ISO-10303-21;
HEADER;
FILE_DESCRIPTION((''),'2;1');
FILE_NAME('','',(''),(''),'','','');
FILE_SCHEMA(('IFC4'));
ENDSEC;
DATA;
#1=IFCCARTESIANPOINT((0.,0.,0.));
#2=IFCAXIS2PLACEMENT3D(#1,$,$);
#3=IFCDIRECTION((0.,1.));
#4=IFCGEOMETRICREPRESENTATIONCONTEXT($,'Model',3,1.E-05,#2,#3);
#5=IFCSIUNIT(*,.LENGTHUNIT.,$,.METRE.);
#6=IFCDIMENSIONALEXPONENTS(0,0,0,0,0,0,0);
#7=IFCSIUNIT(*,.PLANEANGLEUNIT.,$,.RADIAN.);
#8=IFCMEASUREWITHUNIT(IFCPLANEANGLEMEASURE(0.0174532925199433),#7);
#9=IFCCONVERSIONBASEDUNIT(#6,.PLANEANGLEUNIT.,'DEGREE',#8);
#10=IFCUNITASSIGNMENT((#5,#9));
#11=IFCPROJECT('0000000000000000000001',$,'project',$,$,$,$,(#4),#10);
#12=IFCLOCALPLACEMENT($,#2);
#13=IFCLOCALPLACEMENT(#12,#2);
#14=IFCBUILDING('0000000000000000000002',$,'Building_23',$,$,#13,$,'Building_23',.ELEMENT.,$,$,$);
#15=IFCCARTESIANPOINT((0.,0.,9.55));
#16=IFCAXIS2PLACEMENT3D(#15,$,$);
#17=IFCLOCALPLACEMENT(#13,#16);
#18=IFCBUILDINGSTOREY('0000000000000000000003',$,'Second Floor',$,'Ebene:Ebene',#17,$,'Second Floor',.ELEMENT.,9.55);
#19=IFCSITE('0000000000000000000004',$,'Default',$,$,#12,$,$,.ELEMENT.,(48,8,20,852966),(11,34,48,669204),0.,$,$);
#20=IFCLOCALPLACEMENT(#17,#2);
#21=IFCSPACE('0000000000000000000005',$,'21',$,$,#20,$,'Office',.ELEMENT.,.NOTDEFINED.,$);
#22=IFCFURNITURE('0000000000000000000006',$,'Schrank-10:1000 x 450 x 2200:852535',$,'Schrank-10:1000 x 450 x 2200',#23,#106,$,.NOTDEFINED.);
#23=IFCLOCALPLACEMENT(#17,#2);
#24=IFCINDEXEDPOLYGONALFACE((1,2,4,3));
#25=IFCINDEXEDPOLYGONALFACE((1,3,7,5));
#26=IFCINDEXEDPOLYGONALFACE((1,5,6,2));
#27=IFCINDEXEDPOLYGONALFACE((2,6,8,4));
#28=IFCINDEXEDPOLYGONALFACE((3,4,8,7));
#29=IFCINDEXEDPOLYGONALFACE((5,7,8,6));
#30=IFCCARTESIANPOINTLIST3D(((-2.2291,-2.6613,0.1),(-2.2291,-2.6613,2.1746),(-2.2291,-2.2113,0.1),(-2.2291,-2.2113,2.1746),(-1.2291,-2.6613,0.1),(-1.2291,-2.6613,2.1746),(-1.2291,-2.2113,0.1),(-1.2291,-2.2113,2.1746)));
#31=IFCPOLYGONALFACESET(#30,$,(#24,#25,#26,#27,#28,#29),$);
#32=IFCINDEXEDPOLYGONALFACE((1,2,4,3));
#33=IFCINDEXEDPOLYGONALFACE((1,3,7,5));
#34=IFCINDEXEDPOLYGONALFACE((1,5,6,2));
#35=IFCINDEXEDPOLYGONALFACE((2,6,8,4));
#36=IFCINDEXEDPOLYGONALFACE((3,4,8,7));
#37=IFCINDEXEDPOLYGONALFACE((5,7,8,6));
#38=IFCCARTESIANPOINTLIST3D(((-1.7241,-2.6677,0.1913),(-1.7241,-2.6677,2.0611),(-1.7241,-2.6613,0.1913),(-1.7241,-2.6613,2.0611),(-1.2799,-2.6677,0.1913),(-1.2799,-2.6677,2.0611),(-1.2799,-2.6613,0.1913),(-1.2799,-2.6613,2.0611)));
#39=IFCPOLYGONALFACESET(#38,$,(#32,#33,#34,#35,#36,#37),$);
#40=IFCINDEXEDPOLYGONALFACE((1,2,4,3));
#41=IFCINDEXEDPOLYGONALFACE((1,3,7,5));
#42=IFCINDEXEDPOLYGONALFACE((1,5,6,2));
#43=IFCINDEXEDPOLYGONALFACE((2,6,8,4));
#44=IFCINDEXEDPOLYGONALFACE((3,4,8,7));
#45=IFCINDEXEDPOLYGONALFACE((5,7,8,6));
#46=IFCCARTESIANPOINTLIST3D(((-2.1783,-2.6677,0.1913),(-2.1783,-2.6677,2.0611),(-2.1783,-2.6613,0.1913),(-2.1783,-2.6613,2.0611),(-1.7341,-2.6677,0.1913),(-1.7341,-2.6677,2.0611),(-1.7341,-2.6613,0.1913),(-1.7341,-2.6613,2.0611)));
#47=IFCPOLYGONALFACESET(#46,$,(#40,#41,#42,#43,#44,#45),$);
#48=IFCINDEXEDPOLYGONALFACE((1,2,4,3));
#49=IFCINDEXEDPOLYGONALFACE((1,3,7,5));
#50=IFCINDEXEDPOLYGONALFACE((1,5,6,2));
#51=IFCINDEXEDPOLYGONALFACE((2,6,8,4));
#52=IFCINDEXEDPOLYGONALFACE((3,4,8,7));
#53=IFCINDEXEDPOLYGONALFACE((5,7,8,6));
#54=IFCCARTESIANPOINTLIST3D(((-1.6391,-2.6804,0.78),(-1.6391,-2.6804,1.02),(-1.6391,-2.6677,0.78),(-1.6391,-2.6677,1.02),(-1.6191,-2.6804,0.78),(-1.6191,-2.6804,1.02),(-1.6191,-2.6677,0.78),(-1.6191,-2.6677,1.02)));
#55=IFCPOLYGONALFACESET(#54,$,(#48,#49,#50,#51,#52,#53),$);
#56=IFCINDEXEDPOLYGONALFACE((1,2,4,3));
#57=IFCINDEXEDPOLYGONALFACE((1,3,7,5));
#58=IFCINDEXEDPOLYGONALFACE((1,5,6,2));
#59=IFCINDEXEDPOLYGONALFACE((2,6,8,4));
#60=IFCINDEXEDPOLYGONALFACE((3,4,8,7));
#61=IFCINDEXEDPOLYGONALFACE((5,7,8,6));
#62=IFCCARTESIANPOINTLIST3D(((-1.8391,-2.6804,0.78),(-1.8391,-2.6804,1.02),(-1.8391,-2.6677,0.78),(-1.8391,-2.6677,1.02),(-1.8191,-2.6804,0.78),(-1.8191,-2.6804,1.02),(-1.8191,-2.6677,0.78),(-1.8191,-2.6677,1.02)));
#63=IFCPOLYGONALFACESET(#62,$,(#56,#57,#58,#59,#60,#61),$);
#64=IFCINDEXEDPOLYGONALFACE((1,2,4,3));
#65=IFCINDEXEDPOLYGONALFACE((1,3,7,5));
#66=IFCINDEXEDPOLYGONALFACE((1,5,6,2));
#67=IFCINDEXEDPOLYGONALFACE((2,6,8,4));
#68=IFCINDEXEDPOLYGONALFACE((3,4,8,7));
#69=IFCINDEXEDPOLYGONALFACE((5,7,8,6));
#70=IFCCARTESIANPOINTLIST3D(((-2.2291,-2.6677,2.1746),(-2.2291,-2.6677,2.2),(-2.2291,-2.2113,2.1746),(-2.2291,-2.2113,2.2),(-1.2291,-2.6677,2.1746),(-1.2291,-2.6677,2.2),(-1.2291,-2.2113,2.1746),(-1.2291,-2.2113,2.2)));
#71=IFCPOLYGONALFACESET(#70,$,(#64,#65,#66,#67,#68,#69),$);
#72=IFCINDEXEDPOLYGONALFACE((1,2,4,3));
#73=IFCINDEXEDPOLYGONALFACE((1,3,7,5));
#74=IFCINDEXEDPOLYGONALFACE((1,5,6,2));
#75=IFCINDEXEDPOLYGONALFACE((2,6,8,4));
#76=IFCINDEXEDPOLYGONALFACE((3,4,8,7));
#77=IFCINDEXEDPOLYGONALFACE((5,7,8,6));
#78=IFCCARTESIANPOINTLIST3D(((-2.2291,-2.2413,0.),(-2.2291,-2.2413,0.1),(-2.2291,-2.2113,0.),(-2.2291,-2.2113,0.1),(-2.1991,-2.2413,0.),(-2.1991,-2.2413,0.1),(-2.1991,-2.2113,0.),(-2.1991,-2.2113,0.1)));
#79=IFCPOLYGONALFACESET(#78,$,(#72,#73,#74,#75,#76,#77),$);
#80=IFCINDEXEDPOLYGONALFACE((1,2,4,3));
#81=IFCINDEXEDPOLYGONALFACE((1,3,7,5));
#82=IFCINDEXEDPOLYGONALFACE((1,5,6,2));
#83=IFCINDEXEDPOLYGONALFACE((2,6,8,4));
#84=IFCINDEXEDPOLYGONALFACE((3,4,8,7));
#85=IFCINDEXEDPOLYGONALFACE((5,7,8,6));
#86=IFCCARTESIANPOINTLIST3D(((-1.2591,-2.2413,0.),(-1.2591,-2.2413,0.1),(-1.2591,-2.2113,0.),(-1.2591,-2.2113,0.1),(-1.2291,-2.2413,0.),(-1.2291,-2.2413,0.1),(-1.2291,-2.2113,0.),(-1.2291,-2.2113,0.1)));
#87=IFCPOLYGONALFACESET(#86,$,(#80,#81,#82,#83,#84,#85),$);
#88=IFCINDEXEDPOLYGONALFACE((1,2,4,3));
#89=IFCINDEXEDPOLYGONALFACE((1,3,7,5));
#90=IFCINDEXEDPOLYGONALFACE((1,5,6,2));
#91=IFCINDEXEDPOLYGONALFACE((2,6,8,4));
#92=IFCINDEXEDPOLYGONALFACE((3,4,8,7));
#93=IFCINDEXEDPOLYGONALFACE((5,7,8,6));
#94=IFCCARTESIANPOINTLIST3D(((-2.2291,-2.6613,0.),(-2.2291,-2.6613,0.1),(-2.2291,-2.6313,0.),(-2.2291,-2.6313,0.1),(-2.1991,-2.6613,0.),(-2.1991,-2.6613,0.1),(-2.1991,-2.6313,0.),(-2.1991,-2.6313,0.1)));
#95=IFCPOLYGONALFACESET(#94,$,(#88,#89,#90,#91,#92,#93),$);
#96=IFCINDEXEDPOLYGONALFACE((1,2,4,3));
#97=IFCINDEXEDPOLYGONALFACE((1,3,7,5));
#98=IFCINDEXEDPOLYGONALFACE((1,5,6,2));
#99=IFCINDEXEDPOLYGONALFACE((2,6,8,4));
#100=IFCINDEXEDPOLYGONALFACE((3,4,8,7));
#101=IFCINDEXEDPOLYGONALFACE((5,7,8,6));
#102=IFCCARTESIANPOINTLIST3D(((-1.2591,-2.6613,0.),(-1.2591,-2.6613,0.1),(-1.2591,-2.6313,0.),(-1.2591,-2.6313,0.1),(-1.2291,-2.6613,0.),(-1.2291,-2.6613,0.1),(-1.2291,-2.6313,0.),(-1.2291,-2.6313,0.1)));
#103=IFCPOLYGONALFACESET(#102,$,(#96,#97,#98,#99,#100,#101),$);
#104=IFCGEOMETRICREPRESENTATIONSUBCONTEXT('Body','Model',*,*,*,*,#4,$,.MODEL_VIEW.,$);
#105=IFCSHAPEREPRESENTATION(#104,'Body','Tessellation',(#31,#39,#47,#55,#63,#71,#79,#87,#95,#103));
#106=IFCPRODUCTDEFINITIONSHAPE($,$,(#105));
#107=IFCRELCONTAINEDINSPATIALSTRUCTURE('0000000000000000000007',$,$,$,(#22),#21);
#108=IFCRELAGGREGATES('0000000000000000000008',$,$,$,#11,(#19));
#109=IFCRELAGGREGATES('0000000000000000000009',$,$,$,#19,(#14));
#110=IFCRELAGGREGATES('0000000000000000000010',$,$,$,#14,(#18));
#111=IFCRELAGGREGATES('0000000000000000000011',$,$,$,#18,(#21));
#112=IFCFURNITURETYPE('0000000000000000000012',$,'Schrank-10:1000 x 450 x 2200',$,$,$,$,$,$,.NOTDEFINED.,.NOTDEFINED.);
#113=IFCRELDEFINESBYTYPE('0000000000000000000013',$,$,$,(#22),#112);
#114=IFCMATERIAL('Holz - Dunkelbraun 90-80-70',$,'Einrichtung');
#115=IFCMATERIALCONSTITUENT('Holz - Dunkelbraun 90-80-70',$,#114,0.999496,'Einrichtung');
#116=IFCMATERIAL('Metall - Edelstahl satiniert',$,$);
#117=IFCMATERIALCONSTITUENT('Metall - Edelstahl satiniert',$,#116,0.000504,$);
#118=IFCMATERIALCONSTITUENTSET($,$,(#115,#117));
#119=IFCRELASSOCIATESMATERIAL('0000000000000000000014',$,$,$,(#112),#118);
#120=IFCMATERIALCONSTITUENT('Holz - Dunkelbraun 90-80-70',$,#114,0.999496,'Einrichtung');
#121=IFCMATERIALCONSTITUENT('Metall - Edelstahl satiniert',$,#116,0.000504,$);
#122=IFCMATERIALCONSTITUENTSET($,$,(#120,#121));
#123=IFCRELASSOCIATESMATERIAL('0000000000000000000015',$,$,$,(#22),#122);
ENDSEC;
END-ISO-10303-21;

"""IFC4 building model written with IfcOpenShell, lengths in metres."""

from ifc_helpers import new_model, entity, si_unit, converted_unit, direction, frame, origin, place, context, subcontext, project, spatial, indexed_curve, outline, extrude, source, transform, mapped, material, constituent, constituent_set, type_object, type_shapes, element, save


model = new_model("IFC4")

# Units and contexts
model_context = context("Model", 3, precision=1e-05, world=origin(), true_north=direction((0.0, 1.0)))
body_context = subcontext(model_context, "Body", "Model", "MODEL_VIEW")
ifc_project = project(units=[si_unit("LENGTHUNIT", "METRE"), converted_unit("PLANEANGLEUNIT", "DEGREE", entity("IfcPlaneAngleMeasure", 0.0174532925199433), si_unit("PLANEANGLEUNIT", "RADIAN"), dimensions=[0, 0, 0, 0, 0, 0, 0])], contexts=[model_context])

# Site, building, storey
site_placement = place(None, origin())
site = spatial("IfcSite", under=ifc_project, at=site_placement, Name="Default", CompositionType="ELEMENT", RefLatitude=(48, 8, 20, 852966), RefLongitude=(11, 34, 48, 669204), RefElevation=0.0)
building_placement = place(site_placement, origin())
building = spatial("IfcBuilding", under=site, at=building_placement, Name="Building_23", LongName="Building_23", CompositionType="ELEMENT")
storey_placement = place(building_placement, frame((0.0, 0.0, 9.55)))
storey = spatial("IfcBuildingStorey", under=building, at=storey_placement, Name="Second Floor", ObjectType="Ebene:Ebene", LongName="Second Floor", CompositionType="ELEMENT", Elevation=9.55)

# Shared definitions
space_1_placement = place(storey_placement, origin())
space_1 = spatial("IfcSpace", under=storey, at=space_1_placement, Name="21", LongName="Office", CompositionType="ELEMENT", PredefinedType="NOTDEFINED")

# Furniture
ifc_material_1 = material(Name="Holz - Dunkelbraun 90-80-70", Category="Einrichtung")
ifc_constituent_1 = constituent(ifc_material_1, Name="Holz - Dunkelbraun 90-80-70", Category="Einrichtung", fraction=0.999496)
ifc_material_2 = material(Name="Metall - Edelstahl satiniert")
ifc_constituent_2 = constituent(ifc_material_2, Name="Metall - Edelstahl satiniert", fraction=0.000504)
ifc_constituent_set_1 = constituent_set(constituents=[ifc_constituent_1, ifc_constituent_2])
ifc_constituent_3 = constituent(ifc_material_1, Name="Holz - Dunkelbraun 90-80-70", Category="Einrichtung", fraction=0.999496)
ifc_constituent_4 = constituent(ifc_material_2, Name="Metall - Edelstahl satiniert", fraction=0.000504)
ifc_constituent_set_2 = constituent_set(constituents=[ifc_constituent_3, ifc_constituent_4])
furniture_type_1 = type_object("IfcFurnitureType", Name="Schrank-10:1000 x 450 x 2200", AssemblyPlace="NOTDEFINED", PredefinedType="NOTDEFINED", material=ifc_constituent_set_2)
shared_shape_1 = source(origin(), body_context, "Body", "SweptSolid", [
    extrude(outline(indexed_curve([(-0.225, -0.5), (0.225, -0.5), (0.225, 0.5), (-0.225, 0.5), (-0.225, -0.5)], self_intersect=False)), frame((-0.2692, -0.3632, 0.1), z_axis=(0.0, 0.0, 1.0), x_axis=(0.0, 1.0, 0.0)), (0.0, 0.0, 1.0), 2.0746),
    extrude(outline(indexed_curve([(-0.0032, -0.2221), (0.0032, -0.2221), (0.0032, 0.2221), (-0.0032, 0.2221), (-0.0032, -0.2221)], self_intersect=False)), frame((-0.0421, -0.5913, 0.1913), z_axis=(0.0, 0.0, 1.0), x_axis=(0.0, 1.0, 0.0)), (0.0, 0.0, 1.0), 1.8698),
    extrude(outline(indexed_curve([(-0.0032, -0.2221), (0.0032, -0.2221), (0.0032, 0.2221), (-0.0032, 0.2221), (-0.0032, -0.2221)], self_intersect=False)), frame((-0.4963, -0.5913, 0.1913), z_axis=(0.0, 0.0, 1.0), x_axis=(0.0, 1.0, 0.0)), (0.0, 0.0, 1.0), 1.8698),
    extrude(outline(indexed_curve([(-0.0063, -0.01), (0.0063, -0.01), (0.0063, 0.01), (-0.0063, 0.01), (-0.0063, -0.01)], self_intersect=False)), frame((-0.1692, -0.6009, 0.78), z_axis=(0.0, 0.0, 1.0), x_axis=(0.0, 1.0, 0.0)), (0.0, 0.0, 1.0), 0.24),
    extrude(outline(indexed_curve([(-0.0063, -0.01), (0.0063, -0.01), (0.0063, 0.01), (-0.0063, 0.01), (-0.0063, -0.01)], self_intersect=False)), frame((-0.3692, -0.6009, 0.78), z_axis=(0.0, 0.0, 1.0), x_axis=(0.0, 1.0, 0.0)), (0.0, 0.0, 1.0), 0.24),
    extrude(outline(indexed_curve([(-0.5, -0.2282), (0.5, -0.2282), (0.5, 0.2282), (-0.5, 0.2282), (-0.5, -0.2282)], self_intersect=False)), frame((-0.2692, -0.3663, 2.1746), z_axis=(0.0, 0.0, 1.0), x_axis=(-1.0, 0.0, 0.0)), (0.0, 0.0, 1.0), 0.0254),
    extrude(outline(indexed_curve([(-0.015, -0.015), (0.015, -0.015), (0.015, 0.015), (-0.015, 0.015), (-0.015, -0.015)], self_intersect=False)), frame((-0.7542, -0.1532, 0.0), z_axis=(0.0, 0.0, 1.0), x_axis=(-1.0, 0.0, 0.0)), (0.0, 0.0, 1.0), 0.1),
    extrude(outline(indexed_curve([(-0.015, -0.015), (0.015, -0.015), (0.015, 0.015), (-0.015, 0.015), (-0.015, -0.015)], self_intersect=False)), frame((0.2158, -0.1532, 0.0), z_axis=(0.0, 0.0, 1.0), x_axis=(0.0, -1.0, 0.0)), (0.0, 0.0, 1.0), 0.1),
    extrude(outline(indexed_curve([(-0.015, -0.015), (0.015, -0.015), (0.015, 0.015), (-0.015, 0.015), (-0.015, -0.015)], self_intersect=False)), frame((-0.7542, -0.5732, 0.0), z_axis=(0.0, 0.0, 1.0), x_axis=(0.0, 1.0, 0.0)), (0.0, 0.0, 1.0), 0.1),
    extrude(outline(indexed_curve([(-0.015, -0.015), (0.015, -0.015), (0.015, 0.015), (-0.015, 0.015), (-0.015, -0.015)], self_intersect=False)), frame((0.2158, -0.5732, 0.0)), (0.0, 0.0, 1.0), 0.1),
])
type_shapes(furniture_type_1, [shared_shape_1])
furniture_1_placement = place(space_1_placement, frame((-1.4599, -2.0731, 0.0)))
element("IfcFurniture", 1, at=furniture_1_placement, inside=space_1, type_object=furniture_type_1, material=ifc_constituent_set_1, Name="Schrank-10:1000 x 450 x 2200:852535", ObjectType="Schrank-10:1000 x 450 x 2200", PredefinedType="NOTDEFINED", context=body_context, shape_type="MappedRepresentation", body=[
    mapped(shared_shape_1, transform((0.0, 0.0, 0.0), scale=1.0)),
])

save(model, "model.ifc")
